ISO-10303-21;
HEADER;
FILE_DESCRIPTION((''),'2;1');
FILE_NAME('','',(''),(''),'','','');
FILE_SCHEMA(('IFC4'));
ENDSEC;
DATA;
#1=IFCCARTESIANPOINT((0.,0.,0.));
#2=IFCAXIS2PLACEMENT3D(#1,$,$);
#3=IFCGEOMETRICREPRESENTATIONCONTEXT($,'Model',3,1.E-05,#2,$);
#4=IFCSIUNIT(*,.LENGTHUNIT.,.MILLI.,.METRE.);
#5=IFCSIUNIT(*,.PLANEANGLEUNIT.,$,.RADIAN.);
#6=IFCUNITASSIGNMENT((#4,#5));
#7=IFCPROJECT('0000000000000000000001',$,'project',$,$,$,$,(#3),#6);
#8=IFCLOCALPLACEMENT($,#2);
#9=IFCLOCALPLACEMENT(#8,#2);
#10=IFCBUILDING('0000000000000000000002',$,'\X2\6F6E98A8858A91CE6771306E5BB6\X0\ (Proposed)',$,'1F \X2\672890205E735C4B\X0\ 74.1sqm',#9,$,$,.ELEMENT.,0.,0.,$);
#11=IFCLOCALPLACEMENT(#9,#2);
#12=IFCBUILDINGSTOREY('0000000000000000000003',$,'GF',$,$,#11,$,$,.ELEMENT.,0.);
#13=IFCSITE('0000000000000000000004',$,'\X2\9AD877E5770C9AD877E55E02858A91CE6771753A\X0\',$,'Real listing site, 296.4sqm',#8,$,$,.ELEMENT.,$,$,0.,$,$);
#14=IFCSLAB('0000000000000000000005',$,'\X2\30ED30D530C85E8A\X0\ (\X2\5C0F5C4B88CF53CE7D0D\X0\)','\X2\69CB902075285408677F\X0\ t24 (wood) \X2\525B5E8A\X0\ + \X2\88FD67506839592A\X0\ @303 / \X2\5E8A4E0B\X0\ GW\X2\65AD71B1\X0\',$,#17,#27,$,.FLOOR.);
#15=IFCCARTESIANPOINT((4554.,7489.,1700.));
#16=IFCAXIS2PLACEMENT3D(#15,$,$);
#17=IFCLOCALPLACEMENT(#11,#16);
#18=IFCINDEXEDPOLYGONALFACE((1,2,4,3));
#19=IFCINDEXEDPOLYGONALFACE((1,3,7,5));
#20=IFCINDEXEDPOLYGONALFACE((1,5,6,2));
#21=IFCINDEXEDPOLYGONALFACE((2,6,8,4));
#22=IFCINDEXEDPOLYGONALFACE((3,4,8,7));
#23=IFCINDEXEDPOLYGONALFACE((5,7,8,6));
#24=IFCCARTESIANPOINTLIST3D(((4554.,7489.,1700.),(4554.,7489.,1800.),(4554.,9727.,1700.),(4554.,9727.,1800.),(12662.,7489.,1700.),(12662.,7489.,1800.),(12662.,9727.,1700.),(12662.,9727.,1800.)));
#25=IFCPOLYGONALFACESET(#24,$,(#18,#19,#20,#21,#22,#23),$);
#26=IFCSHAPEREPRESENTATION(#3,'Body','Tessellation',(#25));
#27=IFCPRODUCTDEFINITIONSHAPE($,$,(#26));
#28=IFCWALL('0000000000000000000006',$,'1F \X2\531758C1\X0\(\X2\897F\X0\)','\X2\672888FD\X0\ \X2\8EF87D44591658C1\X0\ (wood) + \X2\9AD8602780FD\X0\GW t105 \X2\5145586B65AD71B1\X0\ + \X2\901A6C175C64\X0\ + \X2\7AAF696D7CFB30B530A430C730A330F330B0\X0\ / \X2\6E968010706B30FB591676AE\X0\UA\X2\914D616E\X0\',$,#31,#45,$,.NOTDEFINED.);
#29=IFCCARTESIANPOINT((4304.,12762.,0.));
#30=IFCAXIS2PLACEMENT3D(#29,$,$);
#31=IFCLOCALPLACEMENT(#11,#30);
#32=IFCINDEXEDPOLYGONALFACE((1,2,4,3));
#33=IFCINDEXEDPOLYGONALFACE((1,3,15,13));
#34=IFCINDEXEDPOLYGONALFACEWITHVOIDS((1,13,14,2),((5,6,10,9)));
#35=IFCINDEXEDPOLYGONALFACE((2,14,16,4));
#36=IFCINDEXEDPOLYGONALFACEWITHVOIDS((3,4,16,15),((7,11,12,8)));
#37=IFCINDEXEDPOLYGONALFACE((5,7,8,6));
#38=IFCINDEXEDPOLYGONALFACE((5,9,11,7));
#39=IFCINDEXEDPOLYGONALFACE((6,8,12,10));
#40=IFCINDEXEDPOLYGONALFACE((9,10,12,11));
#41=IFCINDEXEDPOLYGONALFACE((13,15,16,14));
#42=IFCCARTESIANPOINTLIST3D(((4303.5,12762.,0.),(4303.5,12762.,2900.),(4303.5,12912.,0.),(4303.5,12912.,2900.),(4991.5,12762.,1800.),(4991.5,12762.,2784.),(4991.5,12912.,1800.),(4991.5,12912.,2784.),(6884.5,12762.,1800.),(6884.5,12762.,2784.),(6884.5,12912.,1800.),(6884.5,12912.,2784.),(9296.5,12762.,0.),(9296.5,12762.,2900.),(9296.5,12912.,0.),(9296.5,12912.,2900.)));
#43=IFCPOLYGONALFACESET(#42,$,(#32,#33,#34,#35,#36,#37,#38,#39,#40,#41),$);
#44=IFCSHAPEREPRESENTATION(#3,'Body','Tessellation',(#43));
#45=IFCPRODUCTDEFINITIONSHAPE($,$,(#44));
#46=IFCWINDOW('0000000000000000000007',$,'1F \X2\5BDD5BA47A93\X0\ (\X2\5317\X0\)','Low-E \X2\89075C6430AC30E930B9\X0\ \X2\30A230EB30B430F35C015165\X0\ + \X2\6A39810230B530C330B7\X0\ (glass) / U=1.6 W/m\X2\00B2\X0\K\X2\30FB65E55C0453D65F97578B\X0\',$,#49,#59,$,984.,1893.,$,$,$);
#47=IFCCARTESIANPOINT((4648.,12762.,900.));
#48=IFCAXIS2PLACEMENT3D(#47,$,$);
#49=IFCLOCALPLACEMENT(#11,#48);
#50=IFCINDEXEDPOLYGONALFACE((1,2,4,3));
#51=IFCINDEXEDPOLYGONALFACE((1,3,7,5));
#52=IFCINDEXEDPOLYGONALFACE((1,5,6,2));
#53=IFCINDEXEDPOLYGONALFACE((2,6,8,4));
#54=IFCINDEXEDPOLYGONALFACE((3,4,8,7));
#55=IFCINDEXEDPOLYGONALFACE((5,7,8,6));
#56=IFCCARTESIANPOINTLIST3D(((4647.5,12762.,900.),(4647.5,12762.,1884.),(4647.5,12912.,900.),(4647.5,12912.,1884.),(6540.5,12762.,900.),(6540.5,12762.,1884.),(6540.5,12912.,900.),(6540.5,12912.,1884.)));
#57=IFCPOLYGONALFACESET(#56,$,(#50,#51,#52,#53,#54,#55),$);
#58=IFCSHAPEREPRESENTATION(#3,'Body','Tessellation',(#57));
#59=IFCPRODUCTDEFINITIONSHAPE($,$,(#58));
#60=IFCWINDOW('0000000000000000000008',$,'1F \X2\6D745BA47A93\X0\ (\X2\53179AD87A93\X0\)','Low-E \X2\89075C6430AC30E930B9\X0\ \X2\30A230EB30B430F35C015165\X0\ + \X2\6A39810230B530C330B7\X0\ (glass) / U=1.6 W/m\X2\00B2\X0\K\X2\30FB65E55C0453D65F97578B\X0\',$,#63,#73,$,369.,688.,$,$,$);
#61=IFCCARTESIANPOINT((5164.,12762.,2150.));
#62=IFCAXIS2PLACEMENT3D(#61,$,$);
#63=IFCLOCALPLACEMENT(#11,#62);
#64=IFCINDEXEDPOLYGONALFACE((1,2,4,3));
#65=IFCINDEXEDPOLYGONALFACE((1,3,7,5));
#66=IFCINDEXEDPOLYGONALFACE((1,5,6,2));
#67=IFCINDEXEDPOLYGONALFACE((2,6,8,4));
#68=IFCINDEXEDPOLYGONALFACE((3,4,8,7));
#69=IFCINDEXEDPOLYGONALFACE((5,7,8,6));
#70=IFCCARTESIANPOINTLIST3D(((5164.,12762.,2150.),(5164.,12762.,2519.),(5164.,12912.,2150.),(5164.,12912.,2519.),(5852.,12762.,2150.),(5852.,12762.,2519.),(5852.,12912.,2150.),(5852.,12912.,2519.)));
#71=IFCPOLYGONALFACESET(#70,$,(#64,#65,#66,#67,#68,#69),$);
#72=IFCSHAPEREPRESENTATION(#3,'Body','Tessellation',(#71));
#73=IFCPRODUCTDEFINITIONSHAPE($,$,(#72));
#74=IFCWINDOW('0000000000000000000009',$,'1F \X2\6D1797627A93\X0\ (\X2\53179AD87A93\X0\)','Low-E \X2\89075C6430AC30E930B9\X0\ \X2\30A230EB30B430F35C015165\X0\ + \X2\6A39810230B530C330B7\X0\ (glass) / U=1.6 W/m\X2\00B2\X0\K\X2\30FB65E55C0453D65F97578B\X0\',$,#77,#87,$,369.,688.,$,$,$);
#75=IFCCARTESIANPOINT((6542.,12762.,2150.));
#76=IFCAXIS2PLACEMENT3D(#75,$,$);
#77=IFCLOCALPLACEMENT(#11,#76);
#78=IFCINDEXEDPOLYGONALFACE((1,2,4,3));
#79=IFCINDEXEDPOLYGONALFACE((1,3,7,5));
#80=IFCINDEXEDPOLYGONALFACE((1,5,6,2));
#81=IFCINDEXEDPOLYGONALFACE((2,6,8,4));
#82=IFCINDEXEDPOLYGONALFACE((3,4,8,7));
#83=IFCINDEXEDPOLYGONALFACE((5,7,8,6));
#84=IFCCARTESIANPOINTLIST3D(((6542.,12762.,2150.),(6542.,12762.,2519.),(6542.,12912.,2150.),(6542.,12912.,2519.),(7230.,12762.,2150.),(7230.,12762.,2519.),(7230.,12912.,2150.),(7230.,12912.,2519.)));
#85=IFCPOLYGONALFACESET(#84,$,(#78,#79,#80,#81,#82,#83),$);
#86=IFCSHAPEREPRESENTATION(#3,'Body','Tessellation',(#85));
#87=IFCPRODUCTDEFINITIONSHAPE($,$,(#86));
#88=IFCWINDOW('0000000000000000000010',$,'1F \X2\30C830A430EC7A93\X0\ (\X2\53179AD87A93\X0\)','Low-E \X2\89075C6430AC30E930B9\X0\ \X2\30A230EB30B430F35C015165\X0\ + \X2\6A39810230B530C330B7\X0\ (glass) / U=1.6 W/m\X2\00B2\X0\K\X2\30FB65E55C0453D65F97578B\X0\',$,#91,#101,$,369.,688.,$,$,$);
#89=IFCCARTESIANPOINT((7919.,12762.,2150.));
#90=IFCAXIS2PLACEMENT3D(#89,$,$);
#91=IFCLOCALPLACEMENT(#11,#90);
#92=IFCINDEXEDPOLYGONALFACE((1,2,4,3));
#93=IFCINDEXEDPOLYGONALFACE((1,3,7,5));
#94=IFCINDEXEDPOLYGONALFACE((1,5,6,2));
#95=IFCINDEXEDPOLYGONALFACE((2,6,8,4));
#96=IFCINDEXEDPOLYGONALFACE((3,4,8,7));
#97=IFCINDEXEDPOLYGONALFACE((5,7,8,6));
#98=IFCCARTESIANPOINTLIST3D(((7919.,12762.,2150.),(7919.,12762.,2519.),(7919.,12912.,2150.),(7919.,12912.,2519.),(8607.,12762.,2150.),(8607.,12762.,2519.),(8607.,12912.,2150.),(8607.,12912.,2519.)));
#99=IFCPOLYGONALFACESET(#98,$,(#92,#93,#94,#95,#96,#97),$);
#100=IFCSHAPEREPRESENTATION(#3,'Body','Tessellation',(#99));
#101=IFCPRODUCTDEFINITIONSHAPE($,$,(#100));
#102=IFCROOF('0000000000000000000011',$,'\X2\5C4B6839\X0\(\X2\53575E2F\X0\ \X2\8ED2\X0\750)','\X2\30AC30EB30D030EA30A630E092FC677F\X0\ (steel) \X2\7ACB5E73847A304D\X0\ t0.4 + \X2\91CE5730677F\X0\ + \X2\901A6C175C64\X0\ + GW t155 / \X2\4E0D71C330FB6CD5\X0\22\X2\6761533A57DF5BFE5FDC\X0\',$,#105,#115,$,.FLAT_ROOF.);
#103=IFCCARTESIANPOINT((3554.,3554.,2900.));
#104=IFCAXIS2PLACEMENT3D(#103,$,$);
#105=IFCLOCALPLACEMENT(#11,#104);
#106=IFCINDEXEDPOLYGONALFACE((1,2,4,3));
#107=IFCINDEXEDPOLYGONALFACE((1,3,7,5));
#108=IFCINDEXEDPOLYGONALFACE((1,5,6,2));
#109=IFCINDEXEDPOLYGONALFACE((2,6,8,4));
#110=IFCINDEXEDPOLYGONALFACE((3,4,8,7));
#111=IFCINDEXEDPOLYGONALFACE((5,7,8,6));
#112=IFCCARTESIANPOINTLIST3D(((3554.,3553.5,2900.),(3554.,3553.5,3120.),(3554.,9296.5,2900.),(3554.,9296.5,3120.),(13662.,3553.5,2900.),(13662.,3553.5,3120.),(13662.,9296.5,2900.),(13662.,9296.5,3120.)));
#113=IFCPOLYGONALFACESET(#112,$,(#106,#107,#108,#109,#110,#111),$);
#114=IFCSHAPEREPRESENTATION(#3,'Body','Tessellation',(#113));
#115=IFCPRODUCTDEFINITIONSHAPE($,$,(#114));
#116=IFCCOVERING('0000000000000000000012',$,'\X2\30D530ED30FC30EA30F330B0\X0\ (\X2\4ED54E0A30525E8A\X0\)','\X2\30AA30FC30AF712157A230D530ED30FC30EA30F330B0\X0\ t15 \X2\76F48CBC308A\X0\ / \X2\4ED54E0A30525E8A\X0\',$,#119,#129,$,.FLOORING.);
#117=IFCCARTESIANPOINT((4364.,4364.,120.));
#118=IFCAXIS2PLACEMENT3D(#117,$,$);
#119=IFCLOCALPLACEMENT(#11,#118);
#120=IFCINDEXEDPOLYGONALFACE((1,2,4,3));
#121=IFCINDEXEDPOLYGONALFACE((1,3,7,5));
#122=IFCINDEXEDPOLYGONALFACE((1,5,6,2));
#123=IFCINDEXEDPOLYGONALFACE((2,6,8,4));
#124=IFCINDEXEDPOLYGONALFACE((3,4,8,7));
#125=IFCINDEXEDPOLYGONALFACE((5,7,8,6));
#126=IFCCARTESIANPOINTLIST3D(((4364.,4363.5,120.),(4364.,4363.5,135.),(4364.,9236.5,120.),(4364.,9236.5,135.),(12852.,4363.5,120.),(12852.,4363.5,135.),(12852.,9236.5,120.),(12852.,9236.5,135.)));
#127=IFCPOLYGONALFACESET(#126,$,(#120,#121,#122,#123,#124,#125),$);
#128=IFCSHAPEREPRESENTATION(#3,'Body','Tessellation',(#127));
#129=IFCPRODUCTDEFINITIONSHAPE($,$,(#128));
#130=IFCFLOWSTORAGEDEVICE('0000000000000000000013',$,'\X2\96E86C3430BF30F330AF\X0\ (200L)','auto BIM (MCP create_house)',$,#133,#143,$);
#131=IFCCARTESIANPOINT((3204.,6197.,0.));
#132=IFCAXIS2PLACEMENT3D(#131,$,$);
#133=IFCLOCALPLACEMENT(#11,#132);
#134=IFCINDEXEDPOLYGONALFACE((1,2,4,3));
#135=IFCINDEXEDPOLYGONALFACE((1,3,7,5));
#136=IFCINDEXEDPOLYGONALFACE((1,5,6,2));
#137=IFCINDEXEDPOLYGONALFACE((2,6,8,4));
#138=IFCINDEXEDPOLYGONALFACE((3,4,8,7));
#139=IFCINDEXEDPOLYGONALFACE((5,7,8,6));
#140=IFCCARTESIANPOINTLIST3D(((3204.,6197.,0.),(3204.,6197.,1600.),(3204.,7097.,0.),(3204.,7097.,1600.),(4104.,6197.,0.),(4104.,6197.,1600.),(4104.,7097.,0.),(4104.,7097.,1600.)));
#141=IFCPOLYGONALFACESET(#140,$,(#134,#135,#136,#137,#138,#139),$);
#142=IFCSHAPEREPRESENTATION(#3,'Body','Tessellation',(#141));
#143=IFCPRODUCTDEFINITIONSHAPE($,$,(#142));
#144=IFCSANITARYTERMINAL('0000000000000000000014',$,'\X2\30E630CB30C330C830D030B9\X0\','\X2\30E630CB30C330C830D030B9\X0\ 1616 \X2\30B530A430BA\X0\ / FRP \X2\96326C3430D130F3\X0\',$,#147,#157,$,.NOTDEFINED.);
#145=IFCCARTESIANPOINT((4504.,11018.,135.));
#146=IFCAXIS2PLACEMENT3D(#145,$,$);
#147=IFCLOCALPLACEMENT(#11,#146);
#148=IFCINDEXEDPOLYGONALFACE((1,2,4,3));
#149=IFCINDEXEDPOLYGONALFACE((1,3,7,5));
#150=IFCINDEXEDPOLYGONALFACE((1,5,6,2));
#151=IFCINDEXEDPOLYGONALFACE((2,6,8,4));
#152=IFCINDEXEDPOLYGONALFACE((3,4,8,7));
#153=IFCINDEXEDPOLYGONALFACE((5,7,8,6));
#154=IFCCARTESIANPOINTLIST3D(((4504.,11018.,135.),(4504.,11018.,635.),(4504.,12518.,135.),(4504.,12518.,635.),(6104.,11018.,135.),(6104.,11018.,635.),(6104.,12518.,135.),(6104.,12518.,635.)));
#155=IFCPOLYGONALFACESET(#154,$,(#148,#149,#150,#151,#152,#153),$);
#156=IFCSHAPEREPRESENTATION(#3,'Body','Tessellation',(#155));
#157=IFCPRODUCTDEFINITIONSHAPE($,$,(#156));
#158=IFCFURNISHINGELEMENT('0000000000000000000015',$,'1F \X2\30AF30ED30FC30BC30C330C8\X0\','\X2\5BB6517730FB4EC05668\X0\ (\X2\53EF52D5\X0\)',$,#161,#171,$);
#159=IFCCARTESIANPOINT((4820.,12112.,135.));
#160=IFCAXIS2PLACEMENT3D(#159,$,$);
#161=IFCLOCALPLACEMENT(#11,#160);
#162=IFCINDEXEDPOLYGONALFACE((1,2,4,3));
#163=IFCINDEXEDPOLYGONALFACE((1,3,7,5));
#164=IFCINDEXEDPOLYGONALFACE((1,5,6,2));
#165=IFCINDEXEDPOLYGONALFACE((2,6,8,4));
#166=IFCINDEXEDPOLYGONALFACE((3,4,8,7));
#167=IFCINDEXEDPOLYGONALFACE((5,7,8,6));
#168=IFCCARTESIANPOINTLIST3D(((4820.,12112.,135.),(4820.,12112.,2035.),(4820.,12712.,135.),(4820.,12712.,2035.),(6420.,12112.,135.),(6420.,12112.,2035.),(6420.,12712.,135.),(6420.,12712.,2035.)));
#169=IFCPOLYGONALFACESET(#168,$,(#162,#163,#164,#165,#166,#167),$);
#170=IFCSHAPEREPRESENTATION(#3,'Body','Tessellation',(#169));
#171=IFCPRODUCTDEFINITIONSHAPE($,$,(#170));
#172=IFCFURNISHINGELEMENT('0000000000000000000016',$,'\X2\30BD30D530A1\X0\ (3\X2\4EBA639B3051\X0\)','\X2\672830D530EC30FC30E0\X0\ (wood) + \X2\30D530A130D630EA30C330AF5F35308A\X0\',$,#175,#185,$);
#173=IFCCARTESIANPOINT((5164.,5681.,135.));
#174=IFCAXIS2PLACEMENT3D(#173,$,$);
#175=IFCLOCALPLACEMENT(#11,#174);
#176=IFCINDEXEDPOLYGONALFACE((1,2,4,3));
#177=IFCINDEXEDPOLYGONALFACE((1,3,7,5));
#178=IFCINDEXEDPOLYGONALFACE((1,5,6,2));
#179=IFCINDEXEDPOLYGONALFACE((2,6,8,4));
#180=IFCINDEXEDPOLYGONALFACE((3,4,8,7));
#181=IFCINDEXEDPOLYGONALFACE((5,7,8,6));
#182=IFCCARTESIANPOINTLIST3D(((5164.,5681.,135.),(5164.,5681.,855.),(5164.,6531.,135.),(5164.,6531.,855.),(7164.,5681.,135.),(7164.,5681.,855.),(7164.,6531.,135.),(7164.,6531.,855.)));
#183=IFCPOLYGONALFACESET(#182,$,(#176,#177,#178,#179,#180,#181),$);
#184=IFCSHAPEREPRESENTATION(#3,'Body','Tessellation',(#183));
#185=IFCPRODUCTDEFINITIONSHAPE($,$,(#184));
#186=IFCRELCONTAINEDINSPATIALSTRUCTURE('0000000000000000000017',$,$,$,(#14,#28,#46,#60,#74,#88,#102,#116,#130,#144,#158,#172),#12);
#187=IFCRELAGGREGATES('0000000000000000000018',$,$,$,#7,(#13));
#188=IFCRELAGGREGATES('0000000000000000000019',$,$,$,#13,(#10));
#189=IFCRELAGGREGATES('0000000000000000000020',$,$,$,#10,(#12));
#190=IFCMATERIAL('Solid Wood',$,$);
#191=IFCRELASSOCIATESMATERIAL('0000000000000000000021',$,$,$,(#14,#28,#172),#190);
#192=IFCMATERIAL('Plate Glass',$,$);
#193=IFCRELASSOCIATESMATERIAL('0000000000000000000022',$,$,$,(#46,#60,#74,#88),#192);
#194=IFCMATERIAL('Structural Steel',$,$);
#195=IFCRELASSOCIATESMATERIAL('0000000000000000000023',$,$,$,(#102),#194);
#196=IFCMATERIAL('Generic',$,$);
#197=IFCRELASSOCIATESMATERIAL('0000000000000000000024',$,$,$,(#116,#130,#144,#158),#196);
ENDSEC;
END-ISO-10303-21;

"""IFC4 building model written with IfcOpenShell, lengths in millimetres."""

from ifc_helpers import new_model, si_unit, frame, frame_2d, origin, place, context, project, spatial, rectangle, extrude, material, element, fill, save


model = new_model("IFC4")

# Units and contexts
model_context = context("Model", 3, precision=1e-05, world=origin())
ifc_project = project(units=[si_unit("LENGTHUNIT", "METRE", prefix="MILLI"), si_unit("PLANEANGLEUNIT", "RADIAN")], contexts=[model_context])

# Site, building, storey
site_placement = place(None, origin())
site = spatial("IfcSite", under=ifc_project, at=site_placement, Name="高知県高知市薊野東町", ObjectType="Real listing site, 296.4sqm", CompositionType="ELEMENT", RefElevation=0.0)
building_placement = place(site_placement, origin())
building = spatial("IfcBuilding", under=site, at=building_placement, Name="潮風薊野東の家 (Proposed)", ObjectType="1F 木造平屋 74.1sqm", CompositionType="ELEMENT", ElevationOfRefHeight=0.0, ElevationOfTerrain=0.0)
storey_placement = place(building_placement, origin())
storey = spatial("IfcBuildingStorey", under=building, at=storey_placement, Name="GF", CompositionType="ELEMENT", Elevation=0.0)

# Slab
ifc_material_1 = material(Name="Solid Wood")
slab_1_placement = place(storey_placement, frame((4554.0, 7489.0, 1700.0)))
element("IfcSlab", 1, at=slab_1_placement, inside=storey, material=ifc_material_1, Name="ロフト床 (小屋裏収納)", Description="構造用合板 t24 (wood) 剛床 + 製材根太 @303 / 床下 GW断熱", PredefinedType="FLOOR", context=model_context, shape_type="SweptSolid", body=[
    extrude(rectangle(XDim=8108.0, YDim=2238.0, at=frame_2d((4054.0, 1119.0))), frame((4554.0, 7489.0, 1700.0)), (0.0, 0.0, 1.0), 100.0),
])

# Shared definitions
ifc_material_2 = material(Name="Plate Glass")

# Wall, openings, windows
wall_1_placement = place(storey_placement, frame((4304.0, 12762.0, 0.0)))
wall_1 = element("IfcWall", 2, at=wall_1_placement, inside=storey, material=ifc_material_1, Name="1F 北壁(西)", Description="木製 軸組外壁 (wood) + 高性能GW t105 充填断熱 + 通気層 + 窯業系サイディング / 準耐火・外皮UA配慮", PredefinedType="NOTDEFINED", context=model_context, shape_type="SweptSolid", body=[
    extrude(rectangle(XDim=4993.0, YDim=150.0, at=frame_2d((2496.0, 75.0))), frame((4304.0, 12762.0, 0.0)), (0.0, 0.0, 1.0), 2900.0),
])
opening_1_placement = place(storey_placement, frame((4648.0, 12762.0, 900.0)))
opening_1 = element("IfcOpeningElement", 3, at=opening_1_placement, cuts=wall_1, PredefinedType="NOTDEFINED", context=model_context, shape_type="SweptSolid", body=[
    extrude(rectangle(XDim=1893.0, YDim=150.0, at=frame_2d((946.0, 75.0))), frame((4648.0, 12762.0, 900.0)), (0.0, 0.0, 1.0), 984.0),
])
opening_2_placement = place(storey_placement, frame((5164.0, 12762.0, 2150.0)))
opening_2 = element("IfcOpeningElement", 4, at=opening_2_placement, cuts=wall_1, PredefinedType="NOTDEFINED", context=model_context, shape_type="SweptSolid", body=[
    extrude(rectangle(XDim=688.0, YDim=150.0, at=frame_2d((344.0, 75.0))), frame((5164.0, 12762.0, 2150.0)), (0.0, 0.0, 1.0), 369.0),
])
opening_3_placement = place(storey_placement, frame((6542.0, 12762.0, 2150.0)))
opening_3 = element("IfcOpeningElement", 5, at=opening_3_placement, cuts=wall_1, PredefinedType="NOTDEFINED", context=model_context, shape_type="SweptSolid", body=[
    extrude(rectangle(XDim=688.0, YDim=150.0, at=frame_2d((344.0, 75.0))), frame((6542.0, 12762.0, 2150.0)), (0.0, 0.0, 1.0), 369.0),
])
opening_4_placement = place(storey_placement, frame((7919.0, 12762.0, 2150.0)))
opening_4 = element("IfcOpeningElement", 6, at=opening_4_placement, cuts=wall_1, PredefinedType="NOTDEFINED", context=model_context, shape_type="SweptSolid", body=[
    extrude(rectangle(XDim=688.0, YDim=150.0, at=frame_2d((344.0, 75.0))), frame((7919.0, 12762.0, 2150.0)), (0.0, 0.0, 1.0), 369.0),
])
window_1_placement = place(storey_placement, frame((4648.0, 12762.0, 900.0)))
window_1 = element("IfcWindow", 7, at=window_1_placement, inside=storey, material=ifc_material_2, Name="1F 寝室窓 (北)", Description="Low-E 複層ガラス アルゴン封入 + 樹脂サッシ (glass) / U=1.6 W/m²K・日射取得型", OverallHeight=984.0, OverallWidth=1893.0, context=model_context, shape_type="SweptSolid", body=[
    extrude(rectangle(XDim=1893.0, YDim=150.0, at=frame_2d((946.0, 75.0))), frame((4648.0, 12762.0, 900.0)), (0.0, 0.0, 1.0), 984.0),
])
fill(opening_1, window_1)
window_2_placement = place(storey_placement, frame((5164.0, 12762.0, 2150.0)))
window_2 = element("IfcWindow", 8, at=window_2_placement, inside=storey, material=ifc_material_2, Name="1F 浴室窓 (北高窓)", Description="Low-E 複層ガラス アルゴン封入 + 樹脂サッシ (glass) / U=1.6 W/m²K・日射取得型", OverallHeight=369.0, OverallWidth=688.0, context=model_context, shape_type="SweptSolid", body=[
    extrude(rectangle(XDim=688.0, YDim=150.0, at=frame_2d((344.0, 75.0))), frame((5164.0, 12762.0, 2150.0)), (0.0, 0.0, 1.0), 369.0),
])
fill(opening_2, window_2)
window_3_placement = place(storey_placement, frame((6542.0, 12762.0, 2150.0)))
window_3 = element("IfcWindow", 9, at=window_3_placement, inside=storey, material=ifc_material_2, Name="1F 洗面窓 (北高窓)", Description="Low-E 複層ガラス アルゴン封入 + 樹脂サッシ (glass) / U=1.6 W/m²K・日射取得型", OverallHeight=369.0, OverallWidth=688.0, context=model_context, shape_type="SweptSolid", body=[
    extrude(rectangle(XDim=688.0, YDim=150.0, at=frame_2d((344.0, 75.0))), frame((6542.0, 12762.0, 2150.0)), (0.0, 0.0, 1.0), 369.0),
])
fill(opening_3, window_3)
window_4_placement = place(storey_placement, frame((7919.0, 12762.0, 2150.0)))
window_4 = element("IfcWindow", 10, at=window_4_placement, inside=storey, material=ifc_material_2, Name="1F トイレ窓 (北高窓)", Description="Low-E 複層ガラス アルゴン封入 + 樹脂サッシ (glass) / U=1.6 W/m²K・日射取得型", OverallHeight=369.0, OverallWidth=688.0, context=model_context, shape_type="SweptSolid", body=[
    extrude(rectangle(XDim=688.0, YDim=150.0, at=frame_2d((344.0, 75.0))), frame((7919.0, 12762.0, 2150.0)), (0.0, 0.0, 1.0), 369.0),
])
fill(opening_4, window_4)

# Roof
ifc_material_3 = material(Name="Structural Steel")
roof_1_placement = place(storey_placement, frame((3554.0, 3554.0, 2900.0)))
element("IfcRoof", 11, at=roof_1_placement, inside=storey, material=ifc_material_3, Name="屋根(南帯 軒750)", Description="ガルバリウム鋼板 (steel) 立平葺き t0.4 + 野地板 + 通気層 + GW t155 / 不燃・法22条区域対応", PredefinedType="FLAT_ROOF", context=model_context, shape_type="SweptSolid", body=[
    extrude(rectangle(XDim=10108.0, YDim=5743.0, at=frame_2d((5054.0, 2871.0))), frame((3554.0, 3554.0, 2900.0)), (0.0, 0.0, 1.0), 220.0),
])

# Covering
ifc_material_4 = material(Name="Generic")
covering_1_placement = place(storey_placement, frame((4364.0, 4364.0, 120.0)))
element("IfcCovering", 12, at=covering_1_placement, inside=storey, material=ifc_material_4, Name="フローリング (仕上げ床)", Description="オーク無垢フローリング t15 直貼り / 仕上げ床", PredefinedType="FLOORING", context=model_context, shape_type="SweptSolid", body=[
    extrude(rectangle(XDim=8488.0, YDim=4873.0, at=frame_2d((4244.0, 2436.0))), frame((4364.0, 4364.0, 120.0)), (0.0, 0.0, 1.0), 15.0),
])

# Flow storage device
flow_storage_device_placement = place(storey_placement, frame((3204.0, 6197.0, 0.0)))
element("IfcFlowStorageDevice", 13, at=flow_storage_device_placement, inside=storey, material=ifc_material_4, Name="雨水タンク (200L)", Description="auto BIM (MCP create_house)", context=model_context, shape_type="SweptSolid", body=[
    extrude(rectangle(XDim=900.0, YDim=900.0, at=frame_2d((450.0, 450.0))), frame((3204.0, 6197.0, 0.0)), (0.0, 0.0, 1.0), 1600.0),
])

# Sanitary terminal
sanitary_terminal_placement = place(storey_placement, frame((4504.0, 11018.0, 135.0)))
element("IfcSanitaryTerminal", 14, at=sanitary_terminal_placement, inside=storey, material=ifc_material_4, Name="ユニットバス", Description="ユニットバス 1616 サイズ / FRP 防水パン", PredefinedType="NOTDEFINED", context=model_context, shape_type="SweptSolid", body=[
    extrude(rectangle(XDim=1600.0, YDim=1500.0, at=frame_2d((800.0, 750.0))), frame((4504.0, 11018.0, 135.0)), (0.0, 0.0, 1.0), 500.0),
])

# Furnishing elements
furnishing_1_placement = place(storey_placement, frame((4820.0, 12112.0, 135.0)))
element("IfcFurnishingElement", 15, at=furnishing_1_placement, inside=storey, material=ifc_material_4, Name="1F クローゼット", Description="家具・什器 (可動)", context=model_context, shape_type="SweptSolid", body=[
    extrude(rectangle(XDim=1600.0, YDim=600.0, at=frame_2d((800.0, 300.0))), frame((4820.0, 12112.0, 135.0)), (0.0, 0.0, 1.0), 1900.0),
])
furnishing_2_placement = place(storey_placement, frame((5164.0, 5681.0, 135.0)))
element("IfcFurnishingElement", 16, at=furnishing_2_placement, inside=storey, material=ifc_material_1, Name="ソファ (3人掛け)", Description="木フレーム (wood) + ファブリック張り", context=model_context, shape_type="SweptSolid", body=[
    extrude(rectangle(XDim=2000.0, YDim=850.0, at=frame_2d((1000.0, 425.0))), frame((5164.0, 5681.0, 135.0)), (0.0, 0.0, 1.0), 720.0),
])

save(model, "model.ifc")
